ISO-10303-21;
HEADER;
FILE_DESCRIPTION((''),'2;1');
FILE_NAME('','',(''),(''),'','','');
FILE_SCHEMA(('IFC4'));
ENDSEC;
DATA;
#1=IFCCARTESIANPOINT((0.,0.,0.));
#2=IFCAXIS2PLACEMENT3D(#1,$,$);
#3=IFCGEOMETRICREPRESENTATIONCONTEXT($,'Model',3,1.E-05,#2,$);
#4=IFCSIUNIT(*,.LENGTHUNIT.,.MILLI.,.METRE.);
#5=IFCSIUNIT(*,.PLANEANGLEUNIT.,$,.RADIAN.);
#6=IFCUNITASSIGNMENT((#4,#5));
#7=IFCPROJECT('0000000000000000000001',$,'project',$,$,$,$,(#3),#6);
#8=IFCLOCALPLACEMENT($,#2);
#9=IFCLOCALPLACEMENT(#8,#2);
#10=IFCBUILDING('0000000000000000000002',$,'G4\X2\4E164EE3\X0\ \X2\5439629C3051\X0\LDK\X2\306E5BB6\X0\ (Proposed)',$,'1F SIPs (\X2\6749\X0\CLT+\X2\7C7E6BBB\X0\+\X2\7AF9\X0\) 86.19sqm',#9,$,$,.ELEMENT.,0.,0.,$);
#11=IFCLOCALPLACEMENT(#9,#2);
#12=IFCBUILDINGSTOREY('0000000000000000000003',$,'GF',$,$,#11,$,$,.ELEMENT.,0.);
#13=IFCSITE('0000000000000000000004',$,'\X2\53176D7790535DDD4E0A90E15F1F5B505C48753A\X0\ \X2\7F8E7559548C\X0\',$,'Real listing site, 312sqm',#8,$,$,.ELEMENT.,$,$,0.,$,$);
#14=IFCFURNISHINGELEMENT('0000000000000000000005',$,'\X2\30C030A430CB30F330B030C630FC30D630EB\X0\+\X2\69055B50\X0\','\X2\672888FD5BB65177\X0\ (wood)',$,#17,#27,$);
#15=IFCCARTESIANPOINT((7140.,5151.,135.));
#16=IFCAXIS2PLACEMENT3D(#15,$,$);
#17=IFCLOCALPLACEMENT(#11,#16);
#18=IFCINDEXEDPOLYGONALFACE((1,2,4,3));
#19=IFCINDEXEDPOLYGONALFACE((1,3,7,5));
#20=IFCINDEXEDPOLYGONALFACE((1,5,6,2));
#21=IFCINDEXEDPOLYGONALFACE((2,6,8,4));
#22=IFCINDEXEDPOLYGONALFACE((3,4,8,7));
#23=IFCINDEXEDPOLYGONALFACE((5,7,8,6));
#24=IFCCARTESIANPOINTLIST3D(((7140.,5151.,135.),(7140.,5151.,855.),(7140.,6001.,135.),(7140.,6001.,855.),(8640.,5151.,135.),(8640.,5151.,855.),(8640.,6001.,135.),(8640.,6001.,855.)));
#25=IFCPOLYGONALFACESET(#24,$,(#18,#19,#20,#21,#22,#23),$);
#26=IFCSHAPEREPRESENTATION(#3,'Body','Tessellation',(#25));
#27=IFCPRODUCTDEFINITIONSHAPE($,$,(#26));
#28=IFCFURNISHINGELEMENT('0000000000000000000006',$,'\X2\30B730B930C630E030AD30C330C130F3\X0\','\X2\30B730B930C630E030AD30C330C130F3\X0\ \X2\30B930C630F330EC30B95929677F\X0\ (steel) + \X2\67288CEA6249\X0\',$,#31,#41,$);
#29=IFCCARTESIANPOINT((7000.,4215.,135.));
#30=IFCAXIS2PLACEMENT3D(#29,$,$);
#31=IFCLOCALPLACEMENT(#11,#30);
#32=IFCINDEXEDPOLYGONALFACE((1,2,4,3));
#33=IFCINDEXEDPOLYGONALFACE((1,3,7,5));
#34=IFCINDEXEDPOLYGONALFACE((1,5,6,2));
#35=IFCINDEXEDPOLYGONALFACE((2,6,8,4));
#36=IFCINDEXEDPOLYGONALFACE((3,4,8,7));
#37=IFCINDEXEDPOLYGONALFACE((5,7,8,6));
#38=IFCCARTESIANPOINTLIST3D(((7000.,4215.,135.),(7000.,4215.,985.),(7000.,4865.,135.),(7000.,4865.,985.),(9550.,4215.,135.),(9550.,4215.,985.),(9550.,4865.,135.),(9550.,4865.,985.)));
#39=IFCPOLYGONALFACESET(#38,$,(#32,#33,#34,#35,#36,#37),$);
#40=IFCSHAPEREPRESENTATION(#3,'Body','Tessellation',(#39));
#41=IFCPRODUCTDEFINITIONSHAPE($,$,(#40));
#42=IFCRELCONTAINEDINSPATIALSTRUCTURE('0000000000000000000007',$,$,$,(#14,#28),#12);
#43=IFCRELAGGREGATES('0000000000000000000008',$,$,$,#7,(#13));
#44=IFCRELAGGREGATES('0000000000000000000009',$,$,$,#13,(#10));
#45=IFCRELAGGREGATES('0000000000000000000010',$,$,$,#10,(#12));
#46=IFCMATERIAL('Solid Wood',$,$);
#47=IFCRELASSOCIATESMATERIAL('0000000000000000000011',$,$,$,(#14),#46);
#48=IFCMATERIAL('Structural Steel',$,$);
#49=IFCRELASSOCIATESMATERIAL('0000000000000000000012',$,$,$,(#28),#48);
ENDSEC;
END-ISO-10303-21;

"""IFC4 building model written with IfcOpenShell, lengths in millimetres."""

from ifc_helpers import new_model, si_unit, frame, frame_2d, origin, place, context, project, spatial, rectangle, extrude, material, element, save


model = new_model("IFC4")

# Units and contexts
model_context = context("Model", 3, precision=1e-05, world=origin())
ifc_project = project(units=[si_unit("LENGTHUNIT", "METRE", prefix="MILLI"), si_unit("PLANEANGLEUNIT", "RADIAN")], contexts=[model_context])

# Site, building, storey
site_placement = place(None, origin())
site = spatial("IfcSite", under=ifc_project, at=site_placement, Name="北海道川上郡弟子屈町 美留和", ObjectType="Real listing site, 312sqm", CompositionType="ELEMENT", RefElevation=0.0)
building_placement = place(site_placement, origin())
building = spatial("IfcBuilding", under=site, at=building_placement, Name="G4世代 吹抜けLDKの家 (Proposed)", ObjectType="1F SIPs (杉CLT+籾殻+竹) 86.19sqm", CompositionType="ELEMENT", ElevationOfRefHeight=0.0, ElevationOfTerrain=0.0)
storey_placement = place(building_placement, origin())
storey = spatial("IfcBuildingStorey", under=building, at=storey_placement, Name="GF", CompositionType="ELEMENT", Elevation=0.0)

# Shared definitions
ifc_material_1 = material(Name="Solid Wood")

# Shared definitions
ifc_material_2 = material(Name="Structural Steel")

# Furnishing elements
furnishing_1_placement = place(storey_placement, frame((7140.0, 5151.0, 135.0)))
element("IfcFurnishingElement", 1, at=furnishing_1_placement, inside=storey, material=ifc_material_1, Name="ダイニングテーブル+椅子", Description="木製家具 (wood)", context=model_context, shape_type="SweptSolid", body=[
    extrude(rectangle(XDim=1500.0, YDim=850.0, at=frame_2d((750.0, 425.0))), frame((7140.0, 5151.0, 135.0)), (0.0, 0.0, 1.0), 720.0),
])
furnishing_2_placement = place(storey_placement, frame((7000.0, 4215.0, 135.0)))
element("IfcFurnishingElement", 2, at=furnishing_2_placement, inside=storey, material=ifc_material_2, Name="システムキッチン", Description="システムキッチン ステンレス天板 (steel) + 木質扉", context=model_context, shape_type="SweptSolid", body=[
    extrude(rectangle(XDim=2550.0, YDim=650.0, at=frame_2d((1275.0, 325.0))), frame((7000.0, 4215.0, 135.0)), (0.0, 0.0, 1.0), 850.0),
])

save(model, "model.ifc")
